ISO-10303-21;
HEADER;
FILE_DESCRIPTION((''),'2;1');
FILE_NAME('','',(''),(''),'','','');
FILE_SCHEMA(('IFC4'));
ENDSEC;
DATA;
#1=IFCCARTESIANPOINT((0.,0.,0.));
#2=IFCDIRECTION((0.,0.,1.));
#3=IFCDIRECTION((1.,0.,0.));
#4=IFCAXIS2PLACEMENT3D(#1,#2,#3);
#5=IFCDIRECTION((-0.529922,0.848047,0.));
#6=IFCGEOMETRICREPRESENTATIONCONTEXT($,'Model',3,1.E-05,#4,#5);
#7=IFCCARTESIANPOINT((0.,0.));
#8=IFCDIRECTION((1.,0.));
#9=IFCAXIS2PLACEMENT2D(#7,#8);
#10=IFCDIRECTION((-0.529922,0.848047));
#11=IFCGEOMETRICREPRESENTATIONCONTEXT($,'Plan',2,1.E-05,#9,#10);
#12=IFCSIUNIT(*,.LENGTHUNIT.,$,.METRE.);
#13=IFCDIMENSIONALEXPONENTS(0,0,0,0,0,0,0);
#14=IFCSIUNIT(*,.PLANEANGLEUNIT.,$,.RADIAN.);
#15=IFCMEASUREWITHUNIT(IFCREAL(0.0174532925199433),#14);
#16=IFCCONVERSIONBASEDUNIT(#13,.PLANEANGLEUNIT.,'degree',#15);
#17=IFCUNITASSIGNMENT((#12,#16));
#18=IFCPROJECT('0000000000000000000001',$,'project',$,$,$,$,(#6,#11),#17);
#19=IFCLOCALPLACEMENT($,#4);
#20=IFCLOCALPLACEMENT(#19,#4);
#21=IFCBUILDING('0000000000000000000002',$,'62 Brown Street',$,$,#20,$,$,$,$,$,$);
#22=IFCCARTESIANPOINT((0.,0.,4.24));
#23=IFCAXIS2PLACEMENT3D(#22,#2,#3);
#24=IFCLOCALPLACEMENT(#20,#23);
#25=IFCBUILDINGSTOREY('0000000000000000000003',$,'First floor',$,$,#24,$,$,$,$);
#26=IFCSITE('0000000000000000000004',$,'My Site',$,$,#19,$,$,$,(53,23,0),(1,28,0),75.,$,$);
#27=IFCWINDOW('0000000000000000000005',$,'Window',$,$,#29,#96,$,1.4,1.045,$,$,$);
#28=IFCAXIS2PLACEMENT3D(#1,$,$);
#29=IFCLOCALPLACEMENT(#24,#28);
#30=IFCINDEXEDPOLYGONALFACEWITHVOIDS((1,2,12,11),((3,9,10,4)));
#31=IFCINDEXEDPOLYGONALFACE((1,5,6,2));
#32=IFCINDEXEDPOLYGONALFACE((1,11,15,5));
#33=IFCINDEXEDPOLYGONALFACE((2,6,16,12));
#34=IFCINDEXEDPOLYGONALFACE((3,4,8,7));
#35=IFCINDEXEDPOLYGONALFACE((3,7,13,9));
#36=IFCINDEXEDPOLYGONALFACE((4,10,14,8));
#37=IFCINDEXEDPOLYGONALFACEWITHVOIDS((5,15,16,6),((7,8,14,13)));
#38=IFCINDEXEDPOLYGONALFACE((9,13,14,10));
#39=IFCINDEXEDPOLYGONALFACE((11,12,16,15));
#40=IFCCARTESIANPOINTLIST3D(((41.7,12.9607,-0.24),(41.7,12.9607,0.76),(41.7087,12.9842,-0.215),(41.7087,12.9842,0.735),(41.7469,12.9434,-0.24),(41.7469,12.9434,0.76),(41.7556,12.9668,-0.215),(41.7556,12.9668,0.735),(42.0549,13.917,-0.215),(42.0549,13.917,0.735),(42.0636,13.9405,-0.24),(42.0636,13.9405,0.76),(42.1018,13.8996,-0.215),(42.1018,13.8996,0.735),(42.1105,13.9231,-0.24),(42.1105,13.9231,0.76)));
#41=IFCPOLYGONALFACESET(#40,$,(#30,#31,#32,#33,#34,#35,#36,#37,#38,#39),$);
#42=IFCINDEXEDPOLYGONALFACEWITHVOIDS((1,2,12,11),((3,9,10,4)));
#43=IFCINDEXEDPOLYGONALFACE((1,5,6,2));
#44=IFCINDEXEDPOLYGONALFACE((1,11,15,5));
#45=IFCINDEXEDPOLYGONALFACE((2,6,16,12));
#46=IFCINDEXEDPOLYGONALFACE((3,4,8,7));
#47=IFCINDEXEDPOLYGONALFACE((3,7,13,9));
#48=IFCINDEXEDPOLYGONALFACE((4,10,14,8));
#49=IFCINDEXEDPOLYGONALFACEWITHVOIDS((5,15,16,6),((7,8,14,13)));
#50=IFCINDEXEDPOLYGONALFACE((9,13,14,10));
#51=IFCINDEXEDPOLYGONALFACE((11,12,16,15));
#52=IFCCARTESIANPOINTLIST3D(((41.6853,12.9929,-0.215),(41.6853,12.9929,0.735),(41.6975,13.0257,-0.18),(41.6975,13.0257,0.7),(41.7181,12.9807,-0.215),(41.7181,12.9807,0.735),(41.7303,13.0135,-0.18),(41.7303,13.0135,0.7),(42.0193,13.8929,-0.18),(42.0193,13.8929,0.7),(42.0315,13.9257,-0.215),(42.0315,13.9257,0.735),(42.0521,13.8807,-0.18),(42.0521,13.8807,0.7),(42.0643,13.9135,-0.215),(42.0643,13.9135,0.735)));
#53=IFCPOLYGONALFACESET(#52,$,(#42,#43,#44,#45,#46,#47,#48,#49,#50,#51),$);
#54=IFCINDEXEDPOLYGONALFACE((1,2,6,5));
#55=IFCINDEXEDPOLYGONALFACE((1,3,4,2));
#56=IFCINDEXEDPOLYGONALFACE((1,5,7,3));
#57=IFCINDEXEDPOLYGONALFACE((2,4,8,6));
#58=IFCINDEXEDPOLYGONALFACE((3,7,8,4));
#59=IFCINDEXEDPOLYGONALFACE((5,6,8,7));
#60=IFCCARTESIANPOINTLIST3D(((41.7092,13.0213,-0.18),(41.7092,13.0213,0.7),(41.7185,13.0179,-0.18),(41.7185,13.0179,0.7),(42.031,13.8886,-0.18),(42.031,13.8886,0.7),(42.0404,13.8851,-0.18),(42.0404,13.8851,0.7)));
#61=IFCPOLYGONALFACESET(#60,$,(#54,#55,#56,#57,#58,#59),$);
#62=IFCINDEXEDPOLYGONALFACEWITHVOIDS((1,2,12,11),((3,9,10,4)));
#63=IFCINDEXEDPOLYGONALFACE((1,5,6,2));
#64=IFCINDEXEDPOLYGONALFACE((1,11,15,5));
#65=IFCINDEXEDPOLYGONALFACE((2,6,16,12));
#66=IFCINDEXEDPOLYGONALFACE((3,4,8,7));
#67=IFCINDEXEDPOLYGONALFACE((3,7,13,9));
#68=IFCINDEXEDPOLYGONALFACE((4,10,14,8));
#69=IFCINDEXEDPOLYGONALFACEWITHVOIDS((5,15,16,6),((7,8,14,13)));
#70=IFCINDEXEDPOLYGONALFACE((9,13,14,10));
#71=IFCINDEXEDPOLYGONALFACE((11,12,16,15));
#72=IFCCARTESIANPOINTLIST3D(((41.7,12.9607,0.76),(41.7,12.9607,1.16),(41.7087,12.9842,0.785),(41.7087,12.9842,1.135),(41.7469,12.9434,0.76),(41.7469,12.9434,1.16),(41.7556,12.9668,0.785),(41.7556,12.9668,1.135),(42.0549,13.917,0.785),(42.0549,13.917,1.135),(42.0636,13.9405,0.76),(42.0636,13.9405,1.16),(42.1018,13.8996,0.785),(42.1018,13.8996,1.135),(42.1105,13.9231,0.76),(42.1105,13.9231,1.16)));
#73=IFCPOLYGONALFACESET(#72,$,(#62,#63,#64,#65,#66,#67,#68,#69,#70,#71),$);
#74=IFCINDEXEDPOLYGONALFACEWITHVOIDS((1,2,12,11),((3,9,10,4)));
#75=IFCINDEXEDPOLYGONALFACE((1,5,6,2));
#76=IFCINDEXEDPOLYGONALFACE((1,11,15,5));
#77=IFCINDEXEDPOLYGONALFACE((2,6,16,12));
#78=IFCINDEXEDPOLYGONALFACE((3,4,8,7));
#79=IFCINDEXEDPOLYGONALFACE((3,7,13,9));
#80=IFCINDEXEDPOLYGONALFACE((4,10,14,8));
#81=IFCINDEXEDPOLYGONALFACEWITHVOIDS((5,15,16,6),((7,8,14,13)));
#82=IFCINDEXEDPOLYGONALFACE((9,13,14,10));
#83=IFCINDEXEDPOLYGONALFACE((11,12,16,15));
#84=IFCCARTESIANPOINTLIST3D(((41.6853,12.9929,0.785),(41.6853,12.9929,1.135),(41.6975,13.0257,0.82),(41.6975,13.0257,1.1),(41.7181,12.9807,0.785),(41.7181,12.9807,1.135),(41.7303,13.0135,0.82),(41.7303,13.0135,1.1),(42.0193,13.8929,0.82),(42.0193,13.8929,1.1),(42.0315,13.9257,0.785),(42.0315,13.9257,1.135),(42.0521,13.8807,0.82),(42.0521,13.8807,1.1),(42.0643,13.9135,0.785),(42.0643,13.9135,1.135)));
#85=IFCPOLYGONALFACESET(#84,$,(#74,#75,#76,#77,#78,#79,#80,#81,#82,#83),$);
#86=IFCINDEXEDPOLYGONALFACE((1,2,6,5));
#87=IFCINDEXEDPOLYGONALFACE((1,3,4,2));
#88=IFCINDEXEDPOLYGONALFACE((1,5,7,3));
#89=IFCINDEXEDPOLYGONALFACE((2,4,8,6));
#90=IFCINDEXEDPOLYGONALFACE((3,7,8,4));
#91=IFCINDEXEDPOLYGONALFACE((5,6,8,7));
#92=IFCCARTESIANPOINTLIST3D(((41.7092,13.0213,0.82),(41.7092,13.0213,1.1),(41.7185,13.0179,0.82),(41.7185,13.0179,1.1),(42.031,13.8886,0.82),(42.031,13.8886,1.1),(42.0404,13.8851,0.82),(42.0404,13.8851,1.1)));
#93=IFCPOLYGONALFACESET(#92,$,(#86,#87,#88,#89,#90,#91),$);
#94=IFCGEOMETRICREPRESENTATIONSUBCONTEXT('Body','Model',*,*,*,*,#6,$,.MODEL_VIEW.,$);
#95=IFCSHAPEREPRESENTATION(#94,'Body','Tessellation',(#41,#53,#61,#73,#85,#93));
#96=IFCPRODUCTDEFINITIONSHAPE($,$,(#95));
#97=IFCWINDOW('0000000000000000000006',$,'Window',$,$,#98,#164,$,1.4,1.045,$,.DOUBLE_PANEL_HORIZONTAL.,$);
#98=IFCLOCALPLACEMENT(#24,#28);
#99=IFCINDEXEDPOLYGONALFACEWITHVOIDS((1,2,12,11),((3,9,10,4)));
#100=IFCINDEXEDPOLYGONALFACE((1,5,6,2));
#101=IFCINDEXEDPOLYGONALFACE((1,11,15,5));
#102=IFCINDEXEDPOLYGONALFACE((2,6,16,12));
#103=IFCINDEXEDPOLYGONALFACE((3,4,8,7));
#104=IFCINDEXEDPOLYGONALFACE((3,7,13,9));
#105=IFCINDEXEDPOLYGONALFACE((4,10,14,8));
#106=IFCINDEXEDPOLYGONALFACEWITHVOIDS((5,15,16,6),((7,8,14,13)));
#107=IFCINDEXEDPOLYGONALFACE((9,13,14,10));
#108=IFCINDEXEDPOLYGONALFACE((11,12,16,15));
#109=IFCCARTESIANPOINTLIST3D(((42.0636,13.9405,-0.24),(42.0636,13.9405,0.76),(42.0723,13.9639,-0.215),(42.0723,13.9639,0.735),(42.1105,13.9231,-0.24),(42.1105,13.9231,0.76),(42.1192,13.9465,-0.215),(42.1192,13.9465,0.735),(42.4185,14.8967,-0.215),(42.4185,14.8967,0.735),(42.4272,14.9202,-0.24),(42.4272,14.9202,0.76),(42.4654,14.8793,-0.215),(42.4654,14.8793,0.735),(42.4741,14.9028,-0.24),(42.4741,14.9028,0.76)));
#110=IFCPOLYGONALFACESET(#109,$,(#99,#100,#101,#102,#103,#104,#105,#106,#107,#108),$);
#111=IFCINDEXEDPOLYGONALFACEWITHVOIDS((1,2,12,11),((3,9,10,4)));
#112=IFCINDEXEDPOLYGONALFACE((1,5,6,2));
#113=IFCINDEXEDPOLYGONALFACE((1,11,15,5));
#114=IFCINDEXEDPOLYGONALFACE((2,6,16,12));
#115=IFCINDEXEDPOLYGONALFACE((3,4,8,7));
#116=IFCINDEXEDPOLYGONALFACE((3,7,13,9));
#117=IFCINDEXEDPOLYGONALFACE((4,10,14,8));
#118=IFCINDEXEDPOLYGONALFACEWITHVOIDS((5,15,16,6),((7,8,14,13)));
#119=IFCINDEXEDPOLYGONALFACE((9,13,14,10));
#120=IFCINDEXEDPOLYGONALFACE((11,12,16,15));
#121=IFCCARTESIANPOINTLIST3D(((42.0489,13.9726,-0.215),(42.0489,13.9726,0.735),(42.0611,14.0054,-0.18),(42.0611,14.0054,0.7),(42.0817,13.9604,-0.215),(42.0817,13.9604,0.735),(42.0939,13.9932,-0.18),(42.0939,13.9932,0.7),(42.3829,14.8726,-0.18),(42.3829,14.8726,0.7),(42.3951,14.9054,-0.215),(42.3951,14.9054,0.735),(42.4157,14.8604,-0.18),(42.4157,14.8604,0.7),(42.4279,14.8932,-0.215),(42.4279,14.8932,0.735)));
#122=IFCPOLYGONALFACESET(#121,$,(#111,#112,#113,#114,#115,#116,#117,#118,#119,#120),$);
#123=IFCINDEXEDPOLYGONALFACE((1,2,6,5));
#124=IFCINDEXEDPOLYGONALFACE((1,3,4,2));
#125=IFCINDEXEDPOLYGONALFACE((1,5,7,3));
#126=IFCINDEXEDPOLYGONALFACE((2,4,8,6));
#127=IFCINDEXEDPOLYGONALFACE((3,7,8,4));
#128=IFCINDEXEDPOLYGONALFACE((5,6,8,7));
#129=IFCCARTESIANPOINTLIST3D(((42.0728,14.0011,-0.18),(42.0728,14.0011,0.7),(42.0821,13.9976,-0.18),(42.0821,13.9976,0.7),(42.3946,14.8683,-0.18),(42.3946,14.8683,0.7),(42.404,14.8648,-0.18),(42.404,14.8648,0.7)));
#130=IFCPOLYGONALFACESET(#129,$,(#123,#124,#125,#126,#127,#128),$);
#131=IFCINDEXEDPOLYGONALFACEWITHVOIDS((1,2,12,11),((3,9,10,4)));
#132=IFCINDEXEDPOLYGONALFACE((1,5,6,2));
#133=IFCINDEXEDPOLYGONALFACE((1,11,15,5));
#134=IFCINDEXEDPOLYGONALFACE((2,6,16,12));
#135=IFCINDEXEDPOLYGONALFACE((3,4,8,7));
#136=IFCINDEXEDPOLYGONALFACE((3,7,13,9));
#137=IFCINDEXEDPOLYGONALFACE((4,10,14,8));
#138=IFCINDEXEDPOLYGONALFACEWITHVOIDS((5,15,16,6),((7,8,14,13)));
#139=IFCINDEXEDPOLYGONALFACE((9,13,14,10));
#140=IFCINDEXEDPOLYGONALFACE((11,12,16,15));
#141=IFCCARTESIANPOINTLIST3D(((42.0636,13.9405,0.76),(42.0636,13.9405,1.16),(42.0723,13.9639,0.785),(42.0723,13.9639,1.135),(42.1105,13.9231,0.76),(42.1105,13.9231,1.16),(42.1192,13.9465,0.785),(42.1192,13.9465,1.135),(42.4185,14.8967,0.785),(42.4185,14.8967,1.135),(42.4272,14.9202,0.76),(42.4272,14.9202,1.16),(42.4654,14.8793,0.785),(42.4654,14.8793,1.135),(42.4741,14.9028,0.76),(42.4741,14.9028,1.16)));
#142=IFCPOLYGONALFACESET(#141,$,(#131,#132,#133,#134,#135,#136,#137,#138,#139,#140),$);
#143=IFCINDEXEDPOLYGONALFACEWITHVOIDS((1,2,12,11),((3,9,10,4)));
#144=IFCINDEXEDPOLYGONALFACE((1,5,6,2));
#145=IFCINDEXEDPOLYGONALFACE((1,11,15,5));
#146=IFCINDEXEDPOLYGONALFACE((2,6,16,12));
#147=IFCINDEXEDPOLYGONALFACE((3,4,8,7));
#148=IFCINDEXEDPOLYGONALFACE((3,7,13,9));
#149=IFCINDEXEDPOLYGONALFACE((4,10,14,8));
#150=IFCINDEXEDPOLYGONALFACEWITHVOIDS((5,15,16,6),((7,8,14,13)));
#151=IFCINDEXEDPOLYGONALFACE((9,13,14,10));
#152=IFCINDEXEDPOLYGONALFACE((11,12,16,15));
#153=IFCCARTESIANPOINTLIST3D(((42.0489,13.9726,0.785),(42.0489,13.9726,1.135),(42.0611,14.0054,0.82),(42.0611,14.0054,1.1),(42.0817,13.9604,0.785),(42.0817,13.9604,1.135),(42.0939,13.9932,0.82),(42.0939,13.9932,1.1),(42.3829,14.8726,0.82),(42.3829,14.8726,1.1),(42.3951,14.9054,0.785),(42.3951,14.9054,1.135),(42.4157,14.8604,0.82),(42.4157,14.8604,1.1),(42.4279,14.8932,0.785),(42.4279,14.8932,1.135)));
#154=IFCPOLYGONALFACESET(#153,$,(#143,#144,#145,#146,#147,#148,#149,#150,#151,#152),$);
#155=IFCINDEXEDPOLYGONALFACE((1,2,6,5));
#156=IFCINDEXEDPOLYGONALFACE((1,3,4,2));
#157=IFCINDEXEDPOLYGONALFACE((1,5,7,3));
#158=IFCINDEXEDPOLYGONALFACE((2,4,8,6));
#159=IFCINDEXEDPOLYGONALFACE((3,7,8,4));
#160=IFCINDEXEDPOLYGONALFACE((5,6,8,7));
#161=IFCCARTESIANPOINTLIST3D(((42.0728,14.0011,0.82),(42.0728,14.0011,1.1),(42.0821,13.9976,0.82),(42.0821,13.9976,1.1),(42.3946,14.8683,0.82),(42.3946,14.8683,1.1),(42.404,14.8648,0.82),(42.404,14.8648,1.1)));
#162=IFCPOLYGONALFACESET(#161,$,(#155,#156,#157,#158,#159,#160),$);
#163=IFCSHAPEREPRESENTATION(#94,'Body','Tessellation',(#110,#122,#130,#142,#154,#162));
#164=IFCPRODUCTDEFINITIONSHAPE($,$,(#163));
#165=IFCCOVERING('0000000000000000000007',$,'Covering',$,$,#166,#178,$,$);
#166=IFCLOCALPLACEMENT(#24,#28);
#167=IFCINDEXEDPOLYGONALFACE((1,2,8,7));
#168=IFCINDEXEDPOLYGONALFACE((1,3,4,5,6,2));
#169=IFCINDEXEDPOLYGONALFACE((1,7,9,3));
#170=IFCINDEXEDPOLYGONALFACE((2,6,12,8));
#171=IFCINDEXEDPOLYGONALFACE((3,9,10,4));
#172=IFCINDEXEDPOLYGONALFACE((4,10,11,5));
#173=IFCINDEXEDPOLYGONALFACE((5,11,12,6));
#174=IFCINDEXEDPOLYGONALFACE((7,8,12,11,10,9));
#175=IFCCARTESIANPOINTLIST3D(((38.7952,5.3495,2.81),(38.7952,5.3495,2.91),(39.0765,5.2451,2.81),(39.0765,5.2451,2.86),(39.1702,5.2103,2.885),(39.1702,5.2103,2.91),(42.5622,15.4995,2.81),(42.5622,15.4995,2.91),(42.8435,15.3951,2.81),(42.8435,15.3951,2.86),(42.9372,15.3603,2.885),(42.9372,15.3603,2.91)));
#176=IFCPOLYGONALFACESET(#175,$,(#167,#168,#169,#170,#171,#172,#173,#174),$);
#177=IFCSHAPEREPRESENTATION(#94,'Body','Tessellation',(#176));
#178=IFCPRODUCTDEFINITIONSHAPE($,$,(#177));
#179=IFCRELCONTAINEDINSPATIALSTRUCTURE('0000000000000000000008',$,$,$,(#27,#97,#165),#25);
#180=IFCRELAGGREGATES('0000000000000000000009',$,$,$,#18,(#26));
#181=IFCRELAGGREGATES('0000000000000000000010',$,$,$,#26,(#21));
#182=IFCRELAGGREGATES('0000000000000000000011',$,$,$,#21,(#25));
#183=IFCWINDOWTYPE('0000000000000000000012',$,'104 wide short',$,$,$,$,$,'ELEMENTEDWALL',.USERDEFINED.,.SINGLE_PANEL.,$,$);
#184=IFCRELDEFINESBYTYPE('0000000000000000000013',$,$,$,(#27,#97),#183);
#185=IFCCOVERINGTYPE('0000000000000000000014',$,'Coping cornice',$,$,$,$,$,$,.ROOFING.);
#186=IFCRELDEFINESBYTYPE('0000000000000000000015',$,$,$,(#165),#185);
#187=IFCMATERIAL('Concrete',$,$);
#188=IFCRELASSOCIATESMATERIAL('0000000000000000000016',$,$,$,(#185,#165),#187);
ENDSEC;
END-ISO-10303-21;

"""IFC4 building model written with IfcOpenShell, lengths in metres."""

from ifc_helpers import new_model, entity, si_unit, converted_unit, direction, frame, origin_with_axes, origin_2d_with_axis, place, context, subcontext, project, spatial, line, indexed_curve, outline, extrude, shape, source, transform, mapped, material, material_profile, profile_set, profile_usage, type_object, type_shapes, element, save


model = new_model("IFC4")

# Units and contexts
model_context = context("Model", 3, precision=1e-05, world=origin_with_axes(), true_north=direction((-0.529922, 0.848047, 0.0)))
plan_context = context("Plan", 2, precision=1e-05, world=origin_2d_with_axis(), true_north=direction((-0.529922, 0.848047)))
body_context_1 = subcontext(model_context, "Body", "Model", "MODEL_VIEW")
body_context_2 = subcontext(plan_context, "Body", "Plan", "PLAN_VIEW")
ifc_project = project(units=[si_unit("LENGTHUNIT", "METRE"), converted_unit("PLANEANGLEUNIT", "degree", entity("IfcReal", 0.0174532925199433), si_unit("PLANEANGLEUNIT", "RADIAN"), dimensions=[0, 0, 0, 0, 0, 0, 0])], contexts=[model_context, plan_context])

# Site, building, storey
site_placement = place(None, origin_with_axes())
site = spatial("IfcSite", under=ifc_project, at=site_placement, Name="My Site", RefLatitude=(53, 23, 0), RefLongitude=(1, 28, 0), RefElevation=75.0)
building_placement = place(site_placement, origin_with_axes())
building = spatial("IfcBuilding", under=site, at=building_placement, Name="62 Brown Street")
storey_placement = place(building_placement, frame((0.0, 0.0, 4.24), z_axis=(0.0, 0.0, 1.0), x_axis=(1.0, 0.0, 0.0)))
storey = spatial("IfcBuildingStorey", under=building, at=storey_placement, Name="First floor")

# Windows
window_type = type_object("IfcWindowType", Name="104 wide short", ElementType="ELEMENTEDWALL", PartitioningType="SINGLE_PANEL", PredefinedType="USERDEFINED")
shared_shape_1 = source(origin_with_axes(), body_context_1, "Body", "SweptSolid", [
    extrude(outline(indexed_curve([(0.0, 0.0), (1.045, 0.0), (1.045, 1.0), (0.0, 1.0)], segments=[line(1, 2, 3, 4, 1)]), holes=[indexed_curve([(0.025, 0.025), (1.02, 0.025), (1.02, 0.975), (0.025, 0.975)], segments=[line(1, 2, 3, 4, 1)])]), frame((0.0, 0.15, 0.0), z_axis=(0.0, -1.0, 0.0), x_axis=(1.0, 0.0, 0.0)), (0.0, 0.0, -1.0), 0.05),
    extrude(outline(indexed_curve([(0.0, 0.0), (0.995, 0.0), (0.995, 0.95), (0.0, 0.95)], segments=[line(1, 2, 3, 4, 1)]), holes=[indexed_curve([(0.035, 0.035), (0.96, 0.035), (0.96, 0.915), (0.035, 0.915)], segments=[line(1, 2, 3, 4, 1)])]), frame((0.025, 0.19, 0.025), z_axis=(0.0, -1.0, 0.0), x_axis=(1.0, 0.0, 0.0)), (0.0, 0.0, -1.0), 0.035),
    extrude(outline(indexed_curve([(0.035, 0.035), (0.96, 0.035), (0.96, 0.915), (0.035, 0.915)], segments=[line(1, 2, 3, 4, 1)])), frame((0.025, 0.2025, 0.025), z_axis=(0.0, -1.0, 0.0), x_axis=(1.0, 0.0, 0.0)), (0.0, 0.0, -1.0), 0.01),
    extrude(outline(indexed_curve([(0.0, 0.0), (1.045, 0.0), (1.045, 0.4), (0.0, 0.4)], segments=[line(1, 2, 3, 4, 1)]), holes=[indexed_curve([(0.025, 0.025), (1.02, 0.025), (1.02, 0.375), (0.025, 0.375)], segments=[line(1, 2, 3, 4, 1)])]), frame((0.0, 0.15, 1.0), z_axis=(0.0, -1.0, 0.0), x_axis=(1.0, 0.0, 0.0)), (0.0, 0.0, -1.0), 0.05),
    extrude(outline(indexed_curve([(0.0, 0.0), (0.995, 0.0), (0.995, 0.35), (0.0, 0.35)], segments=[line(1, 2, 3, 4, 1)]), holes=[indexed_curve([(0.035, 0.035), (0.96, 0.035), (0.96, 0.315), (0.035, 0.315)], segments=[line(1, 2, 3, 4, 1)])]), frame((0.025, 0.19, 1.025), z_axis=(0.0, -1.0, 0.0), x_axis=(1.0, 0.0, 0.0)), (0.0, 0.0, -1.0), 0.035),
    extrude(outline(indexed_curve([(0.035, 0.035), (0.96, 0.035), (0.96, 0.315), (0.035, 0.315)], segments=[line(1, 2, 3, 4, 1)])), frame((0.025, 0.2025, 1.025), z_axis=(0.0, -1.0, 0.0), x_axis=(1.0, 0.0, 0.0)), (0.0, 0.0, -1.0), 0.01),
])
shared_shape_2 = source(origin_with_axes(), body_context_2, "Body", "Curve2D", [
    entity("IfcIndexedPolyCurve", entity("IfcCartesianPointList2D", [[0.025, 0.15], [1.02, 0.15]])),
    entity("IfcIndexedPolyCurve", entity("IfcCartesianPointList2D", [[0.0, 0.2], [0.025, 0.2], [0.025, 0.15], [0.0, 0.15]]), [entity("IfcLineIndex", [1, 2, 3, 4, 1])]),
    entity("IfcIndexedPolyCurve", entity("IfcCartesianPointList2D", [[1.045, 0.2], [1.02, 0.2], [1.02, 0.15], [1.045, 0.15]]), [entity("IfcLineIndex", [1, 2, 3, 4, 1])]),
    entity("IfcIndexedPolyCurve", entity("IfcCartesianPointList2D", [[0.025, 0.19], [0.06, 0.19], [0.06, 0.225], [0.025, 0.225]]), [entity("IfcLineIndex", [1, 2, 3, 4, 1])]),
    entity("IfcIndexedPolyCurve", entity("IfcCartesianPointList2D", [[1.02, 0.19], [0.985, 0.19], [0.985, 0.225], [1.02, 0.225]]), [entity("IfcLineIndex", [1, 2, 3, 4, 1])]),
    entity("IfcIndexedPolyCurve", entity("IfcCartesianPointList2D", [[0.06, 0.19], [0.985, 0.19]])),
    entity("IfcIndexedPolyCurve", entity("IfcCartesianPointList2D", [[0.06, 0.225], [0.985, 0.225]])),
    entity("IfcIndexedPolyCurve", entity("IfcCartesianPointList2D", [[0.06, 0.2075], [0.985, 0.2075]])),
])
type_shapes(window_type, [shared_shape_1, shared_shape_2])
for number, where, z_axis, x_axis, name in (
    (1, (41.8875, 12.8912, -0.24), (0.0, 0.0, 1.0), (0.347944, 0.937515, 0.0), "Window"),
):
    element("IfcWindow", number, at=place(storey_placement, frame(where, z_axis=z_axis, x_axis=x_axis)), inside=storey, type_object=window_type, Name=name, OverallHeight=1.4, OverallWidth=1.045, shapes=[
        shape(body_context_1, "Body", "MappedRepresentation", [mapped(shared_shape_1, transform((0.0, 0.0, 0.0), x_axis=(1.0, 0.0, 0.0), y_axis=(0.0, 1.0, 0.0), z_axis=(0.0, 0.0, 1.0), scale=1.0))]),
        shape(body_context_2, "Body", "MappedRepresentation", [mapped(shared_shape_2, transform((0.0, 0.0, 0.0), x_axis=(1.0, 0.0, 0.0), y_axis=(0.0, 1.0, 0.0), z_axis=(0.0, 0.0, 1.0), scale=1.0))]),
    ])
window_placement = place(storey_placement, frame((42.2511, 13.8709, -0.24), z_axis=(0.0, 0.0, 1.0), x_axis=(0.347944, 0.937515, 0.0)))
element("IfcWindow", 2, at=window_placement, inside=storey, type_object=window_type, Name="Window", OverallHeight=1.4, OverallWidth=1.045, PartitioningType="DOUBLE_PANEL_HORIZONTAL", shapes=[
    shape(body_context_1, "Body", "MappedRepresentation", [mapped(shared_shape_1, transform((0.0, 0.0, 0.0), x_axis=(1.0, 0.0, 0.0), y_axis=(0.0, 1.0, 0.0), z_axis=(0.0, 0.0, 1.0), scale=1.0))]),
    shape(body_context_2, "Body", "MappedRepresentation", [mapped(shared_shape_2, transform((0.0, 0.0, 0.0), x_axis=(1.0, 0.0, 0.0), y_axis=(0.0, 1.0, 0.0), z_axis=(0.0, 0.0, 1.0), scale=1.0))]),
])

# Covering
ifc_material_1 = material(Name="Concrete")
ifc_material_profile = material_profile(ifc_material_1, outline(indexed_curve([(-0.2, 0.1), (0.2, 0.1), (0.2, 0.075), (0.1, 0.05), (0.1, 0.0), (-0.2, 0.0)], segments=[line(5, 4), line(4, 3), line(3, 2), line(2, 1), line(1, 6), line(6, 5)], self_intersect=False)))
ifc_profile_set = profile_set([ifc_material_profile], Name="cornice")
ifc_profile_usage = profile_usage(ifc_profile_set, cardinal=5)
covering_type = type_object("IfcCoveringType", Name="Coping cornice", PredefinedType="ROOFING", material=ifc_profile_set)
covering_placement = place(storey_placement, frame((42.7497, 15.4299, 2.81), z_axis=(-0.347944, -0.937515, 0.0), x_axis=(0.937515, -0.347944, 0.0)))
element("IfcCovering", 3, at=covering_placement, inside=storey, type_object=covering_type, material=ifc_profile_usage, Name="Covering", context=body_context_1, shape_type="SweptSolid", body=[
    extrude(outline(indexed_curve([(-0.2, 0.1), (0.2, 0.1), (0.2, 0.075), (0.1, 0.05), (0.1, 0.0), (-0.2, 0.0)], segments=[line(5, 4), line(4, 3), line(3, 2), line(2, 1), line(1, 6), line(6, 5)], self_intersect=False)), origin_with_axes(), (0.0, 0.0, 1.0), 10.8265),
])

save(model, "model.ifc")
